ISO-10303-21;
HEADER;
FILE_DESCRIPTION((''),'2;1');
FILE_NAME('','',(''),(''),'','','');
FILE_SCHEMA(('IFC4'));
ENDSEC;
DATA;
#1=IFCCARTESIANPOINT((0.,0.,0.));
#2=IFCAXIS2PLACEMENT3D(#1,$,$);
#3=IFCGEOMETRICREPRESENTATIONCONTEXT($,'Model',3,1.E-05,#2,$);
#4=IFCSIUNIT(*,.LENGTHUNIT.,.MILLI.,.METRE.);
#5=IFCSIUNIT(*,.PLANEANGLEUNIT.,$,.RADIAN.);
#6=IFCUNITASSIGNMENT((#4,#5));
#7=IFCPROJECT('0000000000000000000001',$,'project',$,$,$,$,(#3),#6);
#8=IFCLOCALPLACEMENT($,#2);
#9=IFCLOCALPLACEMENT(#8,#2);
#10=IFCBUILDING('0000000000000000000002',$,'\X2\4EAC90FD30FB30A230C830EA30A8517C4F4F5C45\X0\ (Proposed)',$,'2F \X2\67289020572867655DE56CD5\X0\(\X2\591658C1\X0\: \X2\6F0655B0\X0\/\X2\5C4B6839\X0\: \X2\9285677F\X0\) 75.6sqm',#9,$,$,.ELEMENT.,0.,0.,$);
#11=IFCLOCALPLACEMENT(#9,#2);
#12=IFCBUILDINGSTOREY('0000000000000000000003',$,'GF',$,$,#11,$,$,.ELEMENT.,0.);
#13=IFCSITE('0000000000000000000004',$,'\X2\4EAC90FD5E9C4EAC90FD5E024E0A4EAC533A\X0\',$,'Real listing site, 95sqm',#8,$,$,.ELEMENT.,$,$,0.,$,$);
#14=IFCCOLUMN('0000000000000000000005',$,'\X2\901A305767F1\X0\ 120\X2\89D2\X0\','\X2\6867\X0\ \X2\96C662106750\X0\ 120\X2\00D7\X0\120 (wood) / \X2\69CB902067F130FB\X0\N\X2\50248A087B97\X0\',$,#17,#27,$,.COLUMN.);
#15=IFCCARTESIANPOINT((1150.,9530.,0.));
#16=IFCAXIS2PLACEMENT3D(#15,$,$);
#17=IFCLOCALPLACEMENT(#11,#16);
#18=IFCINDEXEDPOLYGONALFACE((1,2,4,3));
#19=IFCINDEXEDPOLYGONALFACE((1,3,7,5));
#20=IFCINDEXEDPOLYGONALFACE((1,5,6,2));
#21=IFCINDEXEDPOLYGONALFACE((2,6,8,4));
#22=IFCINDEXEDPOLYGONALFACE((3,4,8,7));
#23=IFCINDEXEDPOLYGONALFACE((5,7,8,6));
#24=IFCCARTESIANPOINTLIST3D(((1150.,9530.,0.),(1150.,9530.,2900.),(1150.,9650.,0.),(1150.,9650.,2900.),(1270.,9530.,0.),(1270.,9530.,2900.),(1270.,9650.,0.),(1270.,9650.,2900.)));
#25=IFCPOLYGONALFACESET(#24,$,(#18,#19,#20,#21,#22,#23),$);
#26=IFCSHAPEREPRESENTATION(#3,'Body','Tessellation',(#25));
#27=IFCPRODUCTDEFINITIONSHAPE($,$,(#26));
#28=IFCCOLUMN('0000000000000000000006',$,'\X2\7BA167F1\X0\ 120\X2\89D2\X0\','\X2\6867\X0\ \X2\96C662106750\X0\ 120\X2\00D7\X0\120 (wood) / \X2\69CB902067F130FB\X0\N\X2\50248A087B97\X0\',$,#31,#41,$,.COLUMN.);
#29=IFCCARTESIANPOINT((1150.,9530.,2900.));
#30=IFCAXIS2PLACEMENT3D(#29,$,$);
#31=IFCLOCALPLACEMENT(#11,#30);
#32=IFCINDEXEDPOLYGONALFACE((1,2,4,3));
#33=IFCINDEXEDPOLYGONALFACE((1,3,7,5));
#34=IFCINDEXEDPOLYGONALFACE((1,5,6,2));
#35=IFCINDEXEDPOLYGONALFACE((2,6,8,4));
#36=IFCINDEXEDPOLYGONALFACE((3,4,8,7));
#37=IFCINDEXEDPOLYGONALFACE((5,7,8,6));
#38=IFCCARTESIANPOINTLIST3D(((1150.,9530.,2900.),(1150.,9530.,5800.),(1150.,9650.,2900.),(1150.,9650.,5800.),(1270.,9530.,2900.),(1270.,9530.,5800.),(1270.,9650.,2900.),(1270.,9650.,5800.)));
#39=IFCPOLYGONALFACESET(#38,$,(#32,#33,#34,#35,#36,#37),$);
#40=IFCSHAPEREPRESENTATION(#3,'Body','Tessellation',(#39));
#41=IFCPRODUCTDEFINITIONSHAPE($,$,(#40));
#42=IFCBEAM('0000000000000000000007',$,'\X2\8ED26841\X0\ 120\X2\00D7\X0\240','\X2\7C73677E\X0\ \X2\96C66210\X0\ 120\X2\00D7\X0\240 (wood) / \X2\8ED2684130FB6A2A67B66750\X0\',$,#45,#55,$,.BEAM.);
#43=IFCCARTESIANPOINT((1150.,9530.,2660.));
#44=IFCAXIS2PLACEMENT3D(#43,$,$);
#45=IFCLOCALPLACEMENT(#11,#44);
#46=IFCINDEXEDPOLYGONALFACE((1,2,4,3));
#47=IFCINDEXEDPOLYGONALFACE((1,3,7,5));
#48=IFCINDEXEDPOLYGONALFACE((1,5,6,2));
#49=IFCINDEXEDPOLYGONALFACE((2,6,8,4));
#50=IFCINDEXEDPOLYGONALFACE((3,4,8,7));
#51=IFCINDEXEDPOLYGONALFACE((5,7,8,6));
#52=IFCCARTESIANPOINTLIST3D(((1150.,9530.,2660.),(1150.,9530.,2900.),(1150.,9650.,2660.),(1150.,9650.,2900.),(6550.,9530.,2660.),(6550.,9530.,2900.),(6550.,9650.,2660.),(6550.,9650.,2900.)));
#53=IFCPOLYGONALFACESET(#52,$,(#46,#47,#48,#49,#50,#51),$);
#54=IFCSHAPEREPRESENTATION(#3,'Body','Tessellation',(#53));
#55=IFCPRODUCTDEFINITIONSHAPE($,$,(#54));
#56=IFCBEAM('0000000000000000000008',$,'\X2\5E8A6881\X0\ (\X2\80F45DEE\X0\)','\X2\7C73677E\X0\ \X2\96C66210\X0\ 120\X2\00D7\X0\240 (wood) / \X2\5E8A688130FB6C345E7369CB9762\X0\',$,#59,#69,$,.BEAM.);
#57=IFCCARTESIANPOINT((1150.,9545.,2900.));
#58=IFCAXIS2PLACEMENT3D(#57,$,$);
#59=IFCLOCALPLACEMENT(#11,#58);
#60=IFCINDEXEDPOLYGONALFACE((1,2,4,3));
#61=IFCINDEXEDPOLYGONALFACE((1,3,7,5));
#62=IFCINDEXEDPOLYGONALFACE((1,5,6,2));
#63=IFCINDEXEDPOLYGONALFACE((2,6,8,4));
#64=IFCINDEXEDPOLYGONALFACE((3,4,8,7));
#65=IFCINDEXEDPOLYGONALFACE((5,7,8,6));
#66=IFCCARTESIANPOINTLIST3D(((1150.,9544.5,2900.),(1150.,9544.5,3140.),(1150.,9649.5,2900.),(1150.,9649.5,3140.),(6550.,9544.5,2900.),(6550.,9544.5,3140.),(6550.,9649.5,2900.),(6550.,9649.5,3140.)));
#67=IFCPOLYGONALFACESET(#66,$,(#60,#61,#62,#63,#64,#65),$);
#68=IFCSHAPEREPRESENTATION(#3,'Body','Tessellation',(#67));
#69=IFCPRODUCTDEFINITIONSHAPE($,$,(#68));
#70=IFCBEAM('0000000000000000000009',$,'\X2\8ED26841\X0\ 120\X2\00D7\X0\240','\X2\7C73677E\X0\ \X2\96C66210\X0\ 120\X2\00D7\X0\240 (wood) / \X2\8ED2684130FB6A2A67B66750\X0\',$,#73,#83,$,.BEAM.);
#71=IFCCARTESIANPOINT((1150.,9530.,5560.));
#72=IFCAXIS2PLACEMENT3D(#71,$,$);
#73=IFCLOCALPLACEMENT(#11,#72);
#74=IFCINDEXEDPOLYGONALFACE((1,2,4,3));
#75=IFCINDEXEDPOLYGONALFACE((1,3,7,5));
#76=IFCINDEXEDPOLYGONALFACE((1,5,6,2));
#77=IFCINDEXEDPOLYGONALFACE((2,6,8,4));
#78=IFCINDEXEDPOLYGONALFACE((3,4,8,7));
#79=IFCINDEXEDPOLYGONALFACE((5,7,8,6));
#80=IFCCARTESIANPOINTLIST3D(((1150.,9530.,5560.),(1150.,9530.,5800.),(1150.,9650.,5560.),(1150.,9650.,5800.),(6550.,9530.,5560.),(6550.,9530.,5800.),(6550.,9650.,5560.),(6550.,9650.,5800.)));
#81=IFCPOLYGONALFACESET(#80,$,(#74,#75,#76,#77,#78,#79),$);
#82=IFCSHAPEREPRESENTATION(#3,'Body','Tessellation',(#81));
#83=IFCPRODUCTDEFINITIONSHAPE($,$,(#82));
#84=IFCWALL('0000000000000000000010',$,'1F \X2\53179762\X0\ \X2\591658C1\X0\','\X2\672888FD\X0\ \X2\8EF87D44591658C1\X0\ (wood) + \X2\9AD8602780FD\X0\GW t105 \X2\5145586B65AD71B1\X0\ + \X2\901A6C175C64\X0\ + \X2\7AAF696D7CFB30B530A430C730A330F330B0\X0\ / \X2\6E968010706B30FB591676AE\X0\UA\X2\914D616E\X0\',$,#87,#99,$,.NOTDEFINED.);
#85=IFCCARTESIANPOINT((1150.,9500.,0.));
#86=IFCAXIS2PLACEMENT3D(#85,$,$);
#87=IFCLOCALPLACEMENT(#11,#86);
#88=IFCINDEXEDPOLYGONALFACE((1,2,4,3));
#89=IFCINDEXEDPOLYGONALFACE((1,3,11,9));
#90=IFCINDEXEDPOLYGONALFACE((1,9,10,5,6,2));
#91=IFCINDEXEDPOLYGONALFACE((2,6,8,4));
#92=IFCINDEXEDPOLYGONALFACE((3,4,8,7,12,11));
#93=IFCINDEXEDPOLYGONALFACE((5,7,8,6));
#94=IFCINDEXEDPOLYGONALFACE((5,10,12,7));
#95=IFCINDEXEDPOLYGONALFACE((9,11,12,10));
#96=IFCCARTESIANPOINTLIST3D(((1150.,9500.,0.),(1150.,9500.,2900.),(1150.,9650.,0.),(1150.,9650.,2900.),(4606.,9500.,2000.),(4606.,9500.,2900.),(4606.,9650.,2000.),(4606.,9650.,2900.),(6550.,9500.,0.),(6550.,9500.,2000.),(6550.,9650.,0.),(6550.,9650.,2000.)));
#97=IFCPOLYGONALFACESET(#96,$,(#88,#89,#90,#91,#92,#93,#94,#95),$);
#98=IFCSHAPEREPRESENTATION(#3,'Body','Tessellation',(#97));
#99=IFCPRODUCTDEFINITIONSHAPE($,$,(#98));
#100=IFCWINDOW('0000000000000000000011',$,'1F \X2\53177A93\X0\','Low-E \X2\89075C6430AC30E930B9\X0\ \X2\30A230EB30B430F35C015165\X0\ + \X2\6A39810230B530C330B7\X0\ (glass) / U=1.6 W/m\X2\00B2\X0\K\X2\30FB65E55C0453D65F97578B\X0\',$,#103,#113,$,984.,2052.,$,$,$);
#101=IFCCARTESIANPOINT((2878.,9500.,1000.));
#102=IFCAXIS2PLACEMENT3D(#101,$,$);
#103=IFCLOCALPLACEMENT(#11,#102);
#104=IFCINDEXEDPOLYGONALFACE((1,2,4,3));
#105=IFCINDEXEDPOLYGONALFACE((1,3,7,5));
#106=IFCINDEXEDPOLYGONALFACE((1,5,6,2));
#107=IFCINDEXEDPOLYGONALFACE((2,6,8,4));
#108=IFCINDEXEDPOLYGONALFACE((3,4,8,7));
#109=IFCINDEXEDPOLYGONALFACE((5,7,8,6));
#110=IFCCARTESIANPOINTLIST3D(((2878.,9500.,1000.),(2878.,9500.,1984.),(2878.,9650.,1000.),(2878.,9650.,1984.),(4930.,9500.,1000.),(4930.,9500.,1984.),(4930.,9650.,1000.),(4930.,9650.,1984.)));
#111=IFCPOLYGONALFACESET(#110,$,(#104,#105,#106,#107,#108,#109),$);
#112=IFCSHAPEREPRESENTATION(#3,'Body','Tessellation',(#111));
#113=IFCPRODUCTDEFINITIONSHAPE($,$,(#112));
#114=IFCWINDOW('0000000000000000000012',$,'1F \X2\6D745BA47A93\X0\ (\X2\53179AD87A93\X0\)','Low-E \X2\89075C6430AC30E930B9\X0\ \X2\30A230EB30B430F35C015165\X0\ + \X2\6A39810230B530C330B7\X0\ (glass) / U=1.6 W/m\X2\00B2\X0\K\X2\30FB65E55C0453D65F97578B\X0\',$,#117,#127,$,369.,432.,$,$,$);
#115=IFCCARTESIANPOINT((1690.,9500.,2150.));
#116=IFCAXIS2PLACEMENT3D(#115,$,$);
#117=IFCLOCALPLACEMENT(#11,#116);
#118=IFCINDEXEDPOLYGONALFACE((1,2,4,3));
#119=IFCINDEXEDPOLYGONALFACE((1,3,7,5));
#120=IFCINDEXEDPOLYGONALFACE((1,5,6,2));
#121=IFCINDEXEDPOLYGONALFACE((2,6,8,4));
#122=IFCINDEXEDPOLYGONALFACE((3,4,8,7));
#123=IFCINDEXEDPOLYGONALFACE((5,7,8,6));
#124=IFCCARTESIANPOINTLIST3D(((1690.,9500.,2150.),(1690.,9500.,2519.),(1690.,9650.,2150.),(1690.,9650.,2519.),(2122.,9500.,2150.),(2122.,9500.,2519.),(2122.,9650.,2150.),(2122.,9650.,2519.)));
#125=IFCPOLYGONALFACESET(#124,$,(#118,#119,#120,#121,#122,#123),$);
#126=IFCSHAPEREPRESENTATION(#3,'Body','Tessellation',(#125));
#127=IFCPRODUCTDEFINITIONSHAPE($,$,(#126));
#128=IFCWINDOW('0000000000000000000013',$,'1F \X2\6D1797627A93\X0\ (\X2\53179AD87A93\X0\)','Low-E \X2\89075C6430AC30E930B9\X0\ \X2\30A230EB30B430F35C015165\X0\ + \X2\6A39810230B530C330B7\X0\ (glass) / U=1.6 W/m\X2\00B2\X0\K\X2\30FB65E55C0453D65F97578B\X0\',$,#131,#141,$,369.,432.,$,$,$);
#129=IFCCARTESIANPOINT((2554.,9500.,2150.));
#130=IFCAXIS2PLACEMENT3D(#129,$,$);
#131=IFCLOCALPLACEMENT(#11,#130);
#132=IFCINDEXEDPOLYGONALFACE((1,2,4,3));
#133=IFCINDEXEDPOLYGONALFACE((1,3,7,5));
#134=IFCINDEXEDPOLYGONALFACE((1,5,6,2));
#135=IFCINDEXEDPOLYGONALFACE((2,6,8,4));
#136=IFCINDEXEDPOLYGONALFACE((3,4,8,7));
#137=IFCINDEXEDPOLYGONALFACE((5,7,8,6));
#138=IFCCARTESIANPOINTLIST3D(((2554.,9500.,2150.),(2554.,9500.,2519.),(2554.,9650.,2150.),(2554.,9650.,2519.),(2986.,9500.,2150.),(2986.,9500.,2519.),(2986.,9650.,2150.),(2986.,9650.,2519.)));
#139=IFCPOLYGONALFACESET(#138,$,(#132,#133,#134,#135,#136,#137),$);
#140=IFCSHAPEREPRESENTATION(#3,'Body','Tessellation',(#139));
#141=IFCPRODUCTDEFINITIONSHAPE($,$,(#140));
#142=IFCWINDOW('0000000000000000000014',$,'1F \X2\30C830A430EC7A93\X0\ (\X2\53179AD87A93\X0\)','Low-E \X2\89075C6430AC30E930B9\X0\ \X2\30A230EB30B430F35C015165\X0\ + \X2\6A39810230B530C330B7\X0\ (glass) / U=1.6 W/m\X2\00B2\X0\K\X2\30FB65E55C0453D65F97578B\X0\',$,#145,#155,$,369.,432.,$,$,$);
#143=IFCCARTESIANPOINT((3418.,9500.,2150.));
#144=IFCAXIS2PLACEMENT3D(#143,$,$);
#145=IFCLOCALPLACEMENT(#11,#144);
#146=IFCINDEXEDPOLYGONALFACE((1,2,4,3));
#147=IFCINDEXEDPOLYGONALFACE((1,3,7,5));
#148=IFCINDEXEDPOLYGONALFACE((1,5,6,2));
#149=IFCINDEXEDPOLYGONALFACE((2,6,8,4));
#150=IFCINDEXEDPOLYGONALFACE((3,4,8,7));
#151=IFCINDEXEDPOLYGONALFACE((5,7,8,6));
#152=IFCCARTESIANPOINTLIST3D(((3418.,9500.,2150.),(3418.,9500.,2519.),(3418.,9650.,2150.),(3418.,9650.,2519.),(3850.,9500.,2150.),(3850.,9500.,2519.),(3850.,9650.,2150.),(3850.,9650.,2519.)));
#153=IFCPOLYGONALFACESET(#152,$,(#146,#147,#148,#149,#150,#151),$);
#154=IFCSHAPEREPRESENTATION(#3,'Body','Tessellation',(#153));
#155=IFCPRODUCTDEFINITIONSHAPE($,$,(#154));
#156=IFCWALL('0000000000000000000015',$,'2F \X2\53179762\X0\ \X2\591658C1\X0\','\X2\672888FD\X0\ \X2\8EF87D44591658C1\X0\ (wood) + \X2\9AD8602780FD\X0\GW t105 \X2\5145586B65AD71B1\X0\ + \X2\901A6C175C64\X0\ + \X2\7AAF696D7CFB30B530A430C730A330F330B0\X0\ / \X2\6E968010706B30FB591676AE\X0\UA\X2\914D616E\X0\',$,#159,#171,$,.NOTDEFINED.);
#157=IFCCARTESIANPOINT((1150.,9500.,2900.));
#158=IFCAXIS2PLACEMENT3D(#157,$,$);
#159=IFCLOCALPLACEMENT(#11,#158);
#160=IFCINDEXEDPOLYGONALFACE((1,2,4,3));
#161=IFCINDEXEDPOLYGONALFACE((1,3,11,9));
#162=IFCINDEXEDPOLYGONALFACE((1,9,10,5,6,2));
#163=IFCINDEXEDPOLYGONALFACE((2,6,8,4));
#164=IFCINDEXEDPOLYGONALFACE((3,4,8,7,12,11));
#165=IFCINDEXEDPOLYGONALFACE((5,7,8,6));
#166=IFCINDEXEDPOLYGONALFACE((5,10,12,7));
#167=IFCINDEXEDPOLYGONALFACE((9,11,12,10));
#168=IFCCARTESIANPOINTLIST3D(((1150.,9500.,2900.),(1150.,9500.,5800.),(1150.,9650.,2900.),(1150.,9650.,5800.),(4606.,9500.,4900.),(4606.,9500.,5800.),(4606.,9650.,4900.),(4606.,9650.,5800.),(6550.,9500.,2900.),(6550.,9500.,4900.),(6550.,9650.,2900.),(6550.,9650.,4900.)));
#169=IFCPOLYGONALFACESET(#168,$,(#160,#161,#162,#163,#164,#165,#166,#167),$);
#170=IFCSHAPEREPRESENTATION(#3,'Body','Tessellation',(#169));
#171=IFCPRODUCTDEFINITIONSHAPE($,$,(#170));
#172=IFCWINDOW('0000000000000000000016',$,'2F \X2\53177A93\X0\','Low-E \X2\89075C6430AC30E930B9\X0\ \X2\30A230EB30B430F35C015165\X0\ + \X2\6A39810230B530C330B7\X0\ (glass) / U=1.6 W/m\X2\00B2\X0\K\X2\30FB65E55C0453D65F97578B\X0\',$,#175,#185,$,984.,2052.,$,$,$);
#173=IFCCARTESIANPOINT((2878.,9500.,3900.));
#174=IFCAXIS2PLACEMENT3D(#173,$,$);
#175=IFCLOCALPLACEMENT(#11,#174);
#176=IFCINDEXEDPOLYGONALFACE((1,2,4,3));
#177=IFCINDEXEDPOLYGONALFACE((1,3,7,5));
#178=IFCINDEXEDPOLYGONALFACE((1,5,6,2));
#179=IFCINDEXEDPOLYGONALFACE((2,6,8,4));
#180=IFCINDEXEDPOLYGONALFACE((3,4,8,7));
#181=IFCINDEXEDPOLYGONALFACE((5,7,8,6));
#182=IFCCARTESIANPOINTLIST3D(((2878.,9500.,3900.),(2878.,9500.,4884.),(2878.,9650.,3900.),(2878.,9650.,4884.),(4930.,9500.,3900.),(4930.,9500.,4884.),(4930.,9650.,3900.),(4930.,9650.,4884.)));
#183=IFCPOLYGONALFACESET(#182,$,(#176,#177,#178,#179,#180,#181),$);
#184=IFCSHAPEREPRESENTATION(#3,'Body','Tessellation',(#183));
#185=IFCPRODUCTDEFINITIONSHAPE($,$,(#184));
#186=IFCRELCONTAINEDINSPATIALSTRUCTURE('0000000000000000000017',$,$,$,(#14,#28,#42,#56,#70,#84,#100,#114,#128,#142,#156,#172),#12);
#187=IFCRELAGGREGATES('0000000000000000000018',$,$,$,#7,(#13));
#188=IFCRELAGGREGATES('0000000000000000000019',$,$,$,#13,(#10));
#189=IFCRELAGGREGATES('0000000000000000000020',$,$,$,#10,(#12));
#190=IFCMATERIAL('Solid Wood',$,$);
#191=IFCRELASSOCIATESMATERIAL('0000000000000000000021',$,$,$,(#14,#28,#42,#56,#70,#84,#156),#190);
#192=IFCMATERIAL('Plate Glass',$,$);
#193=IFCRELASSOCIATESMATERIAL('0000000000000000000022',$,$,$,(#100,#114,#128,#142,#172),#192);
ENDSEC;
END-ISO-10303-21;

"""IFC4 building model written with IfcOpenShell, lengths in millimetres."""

from ifc_helpers import new_model, si_unit, frame, frame_2d, origin, place, context, project, spatial, rectangle, extrude, material, element, fill, save


model = new_model("IFC4")

# Units and contexts
model_context = context("Model", 3, precision=1e-05, world=origin())
ifc_project = project(units=[si_unit("LENGTHUNIT", "METRE", prefix="MILLI"), si_unit("PLANEANGLEUNIT", "RADIAN")], contexts=[model_context])

# Site, building, storey
site_placement = place(None, origin())
site = spatial("IfcSite", under=ifc_project, at=site_placement, Name="京都府京都市上京区", ObjectType="Real listing site, 95sqm", CompositionType="ELEMENT", RefElevation=0.0)
building_placement = place(site_placement, origin())
building = spatial("IfcBuilding", under=site, at=building_placement, Name="京都・アトリエ兼住居 (Proposed)", ObjectType="2F 木造在来工法(外壁: 漆喰/屋根: 銅板) 75.6sqm", CompositionType="ELEMENT", ElevationOfRefHeight=0.0, ElevationOfTerrain=0.0)
storey_placement = place(building_placement, origin())
storey = spatial("IfcBuildingStorey", under=building, at=storey_placement, Name="GF", CompositionType="ELEMENT", Elevation=0.0)

# Columns
ifc_material_1 = material(Name="Solid Wood")
column_1_placement = place(storey_placement, frame((1150.0, 9530.0, 0.0)))
element("IfcColumn", 1, at=column_1_placement, inside=storey, material=ifc_material_1, Name="通し柱 120角", Description="桧 集成材 120×120 (wood) / 構造柱・N値計算", PredefinedType="COLUMN", context=model_context, shape_type="SweptSolid", body=[
    extrude(rectangle(XDim=120.0, YDim=120.0, at=frame_2d((60.0, 60.0))), frame((1150.0, 9530.0, 0.0)), (0.0, 0.0, 1.0), 2900.0),
])
column_2_placement = place(storey_placement, frame((1150.0, 9530.0, 2900.0)))
element("IfcColumn", 2, at=column_2_placement, inside=storey, material=ifc_material_1, Name="管柱 120角", Description="桧 集成材 120×120 (wood) / 構造柱・N値計算", PredefinedType="COLUMN", context=model_context, shape_type="SweptSolid", body=[
    extrude(rectangle(XDim=120.0, YDim=120.0, at=frame_2d((60.0, 60.0))), frame((1150.0, 9530.0, 2900.0)), (0.0, 0.0, 1.0), 2900.0),
])

# Beams
beam_1_placement = place(storey_placement, frame((1150.0, 9530.0, 2660.0)))
element("IfcBeam", 3, at=beam_1_placement, inside=storey, material=ifc_material_1, Name="軒桁 120×240", Description="米松 集成 120×240 (wood) / 軒桁・横架材", PredefinedType="BEAM", context=model_context, shape_type="SweptSolid", body=[
    extrude(rectangle(XDim=5400.0, YDim=120.0, at=frame_2d((2700.0, 60.0))), frame((1150.0, 9530.0, 2660.0)), (0.0, 0.0, 1.0), 240.0),
])
beam_2_placement = place(storey_placement, frame((1150.0, 9545.0, 2900.0)))
element("IfcBeam", 4, at=beam_2_placement, inside=storey, material=ifc_material_1, Name="床梁 (胴差)", Description="米松 集成 120×240 (wood) / 床梁・水平構面", PredefinedType="BEAM", context=model_context, shape_type="SweptSolid", body=[
    extrude(rectangle(XDim=5400.0, YDim=105.0, at=frame_2d((2700.0, 52.0))), frame((1150.0, 9545.0, 2900.0)), (0.0, 0.0, 1.0), 240.0),
])
beam_3_placement = place(storey_placement, frame((1150.0, 9530.0, 5560.0)))
element("IfcBeam", 5, at=beam_3_placement, inside=storey, material=ifc_material_1, Name="軒桁 120×240", Description="米松 集成 120×240 (wood) / 軒桁・横架材", PredefinedType="BEAM", context=model_context, shape_type="SweptSolid", body=[
    extrude(rectangle(XDim=5400.0, YDim=120.0, at=frame_2d((2700.0, 60.0))), frame((1150.0, 9530.0, 5560.0)), (0.0, 0.0, 1.0), 240.0),
])

# Wall, openings, windows
wall_1_placement = place(storey_placement, frame((1150.0, 9500.0, 0.0)))
wall_1 = element("IfcWall", 6, at=wall_1_placement, inside=storey, material=ifc_material_1, Name="1F 北面 外壁", Description="木製 軸組外壁 (wood) + 高性能GW t105 充填断熱 + 通気層 + 窯業系サイディング / 準耐火・外皮UA配慮", PredefinedType="NOTDEFINED", context=model_context, shape_type="SweptSolid", body=[
    extrude(rectangle(XDim=5400.0, YDim=150.0, at=frame_2d((2700.0, 75.0))), frame((1150.0, 9500.0, 0.0)), (0.0, 0.0, 1.0), 2900.0),
])
opening_1_placement = place(storey_placement, frame((2878.0, 9500.0, 1000.0)))
opening_1 = element("IfcOpeningElement", 7, at=opening_1_placement, cuts=wall_1, PredefinedType="NOTDEFINED", context=model_context, shape_type="SweptSolid", body=[
    extrude(rectangle(XDim=2052.0, YDim=150.0, at=frame_2d((1026.0, 75.0))), frame((2878.0, 9500.0, 1000.0)), (0.0, 0.0, 1.0), 984.0),
])
opening_2_placement = place(storey_placement, frame((1690.0, 9500.0, 2150.0)))
opening_2 = element("IfcOpeningElement", 8, at=opening_2_placement, cuts=wall_1, PredefinedType="NOTDEFINED", context=model_context, shape_type="SweptSolid", body=[
    extrude(rectangle(XDim=432.0, YDim=150.0, at=frame_2d((216.0, 75.0))), frame((1690.0, 9500.0, 2150.0)), (0.0, 0.0, 1.0), 369.0),
])
opening_3_placement = place(storey_placement, frame((2554.0, 9500.0, 2150.0)))
opening_3 = element("IfcOpeningElement", 9, at=opening_3_placement, cuts=wall_1, PredefinedType="NOTDEFINED", context=model_context, shape_type="SweptSolid", body=[
    extrude(rectangle(XDim=432.0, YDim=150.0, at=frame_2d((216.0, 75.0))), frame((2554.0, 9500.0, 2150.0)), (0.0, 0.0, 1.0), 369.0),
])
opening_4_placement = place(storey_placement, frame((3418.0, 9500.0, 2150.0)))
opening_4 = element("IfcOpeningElement", 10, at=opening_4_placement, cuts=wall_1, PredefinedType="NOTDEFINED", context=model_context, shape_type="SweptSolid", body=[
    extrude(rectangle(XDim=432.0, YDim=150.0, at=frame_2d((216.0, 75.0))), frame((3418.0, 9500.0, 2150.0)), (0.0, 0.0, 1.0), 369.0),
])
ifc_material_2 = material(Name="Plate Glass")
window_1_placement = place(storey_placement, frame((2878.0, 9500.0, 1000.0)))
window_1 = element("IfcWindow", 11, at=window_1_placement, inside=storey, material=ifc_material_2, Name="1F 北窓", Description="Low-E 複層ガラス アルゴン封入 + 樹脂サッシ (glass) / U=1.6 W/m²K・日射取得型", OverallHeight=984.0, OverallWidth=2052.0, context=model_context, shape_type="SweptSolid", body=[
    extrude(rectangle(XDim=2052.0, YDim=150.0, at=frame_2d((1026.0, 75.0))), frame((2878.0, 9500.0, 1000.0)), (0.0, 0.0, 1.0), 984.0),
])
fill(opening_1, window_1)
window_2_placement = place(storey_placement, frame((1690.0, 9500.0, 2150.0)))
window_2 = element("IfcWindow", 12, at=window_2_placement, inside=storey, material=ifc_material_2, Name="1F 浴室窓 (北高窓)", Description="Low-E 複層ガラス アルゴン封入 + 樹脂サッシ (glass) / U=1.6 W/m²K・日射取得型", OverallHeight=369.0, OverallWidth=432.0, context=model_context, shape_type="SweptSolid", body=[
    extrude(rectangle(XDim=432.0, YDim=150.0, at=frame_2d((216.0, 75.0))), frame((1690.0, 9500.0, 2150.0)), (0.0, 0.0, 1.0), 369.0),
])
fill(opening_2, window_2)
window_3_placement = place(storey_placement, frame((2554.0, 9500.0, 2150.0)))
window_3 = element("IfcWindow", 13, at=window_3_placement, inside=storey, material=ifc_material_2, Name="1F 洗面窓 (北高窓)", Description="Low-E 複層ガラス アルゴン封入 + 樹脂サッシ (glass) / U=1.6 W/m²K・日射取得型", OverallHeight=369.0, OverallWidth=432.0, context=model_context, shape_type="SweptSolid", body=[
    extrude(rectangle(XDim=432.0, YDim=150.0, at=frame_2d((216.0, 75.0))), frame((2554.0, 9500.0, 2150.0)), (0.0, 0.0, 1.0), 369.0),
])
fill(opening_3, window_3)
window_4_placement = place(storey_placement, frame((3418.0, 9500.0, 2150.0)))
window_4 = element("IfcWindow", 14, at=window_4_placement, inside=storey, material=ifc_material_2, Name="1F トイレ窓 (北高窓)", Description="Low-E 複層ガラス アルゴン封入 + 樹脂サッシ (glass) / U=1.6 W/m²K・日射取得型", OverallHeight=369.0, OverallWidth=432.0, context=model_context, shape_type="SweptSolid", body=[
    extrude(rectangle(XDim=432.0, YDim=150.0, at=frame_2d((216.0, 75.0))), frame((3418.0, 9500.0, 2150.0)), (0.0, 0.0, 1.0), 369.0),
])
fill(opening_4, window_4)

# Wall, opening, window
wall_2_placement = place(storey_placement, frame((1150.0, 9500.0, 2900.0)))
wall_2 = element("IfcWall", 15, at=wall_2_placement, inside=storey, material=ifc_material_1, Name="2F 北面 外壁", Description="木製 軸組外壁 (wood) + 高性能GW t105 充填断熱 + 通気層 + 窯業系サイディング / 準耐火・外皮UA配慮", PredefinedType="NOTDEFINED", context=model_context, shape_type="SweptSolid", body=[
    extrude(rectangle(XDim=5400.0, YDim=150.0, at=frame_2d((2700.0, 75.0))), frame((1150.0, 9500.0, 2900.0)), (0.0, 0.0, 1.0), 2900.0),
])
opening_5_placement = place(storey_placement, frame((2878.0, 9500.0, 3900.0)))
opening_5 = element("IfcOpeningElement", 16, at=opening_5_placement, cuts=wall_2, PredefinedType="NOTDEFINED", context=model_context, shape_type="SweptSolid", body=[
    extrude(rectangle(XDim=2052.0, YDim=150.0, at=frame_2d((1026.0, 75.0))), frame((2878.0, 9500.0, 3900.0)), (0.0, 0.0, 1.0), 984.0),
])
window_5_placement = place(storey_placement, frame((2878.0, 9500.0, 3900.0)))
window_5 = element("IfcWindow", 17, at=window_5_placement, inside=storey, material=ifc_material_2, Name="2F 北窓", Description="Low-E 複層ガラス アルゴン封入 + 樹脂サッシ (glass) / U=1.6 W/m²K・日射取得型", OverallHeight=984.0, OverallWidth=2052.0, context=model_context, shape_type="SweptSolid", body=[
    extrude(rectangle(XDim=2052.0, YDim=150.0, at=frame_2d((1026.0, 75.0))), frame((2878.0, 9500.0, 3900.0)), (0.0, 0.0, 1.0), 984.0),
])
fill(opening_5, window_5)

save(model, "model.ifc")
